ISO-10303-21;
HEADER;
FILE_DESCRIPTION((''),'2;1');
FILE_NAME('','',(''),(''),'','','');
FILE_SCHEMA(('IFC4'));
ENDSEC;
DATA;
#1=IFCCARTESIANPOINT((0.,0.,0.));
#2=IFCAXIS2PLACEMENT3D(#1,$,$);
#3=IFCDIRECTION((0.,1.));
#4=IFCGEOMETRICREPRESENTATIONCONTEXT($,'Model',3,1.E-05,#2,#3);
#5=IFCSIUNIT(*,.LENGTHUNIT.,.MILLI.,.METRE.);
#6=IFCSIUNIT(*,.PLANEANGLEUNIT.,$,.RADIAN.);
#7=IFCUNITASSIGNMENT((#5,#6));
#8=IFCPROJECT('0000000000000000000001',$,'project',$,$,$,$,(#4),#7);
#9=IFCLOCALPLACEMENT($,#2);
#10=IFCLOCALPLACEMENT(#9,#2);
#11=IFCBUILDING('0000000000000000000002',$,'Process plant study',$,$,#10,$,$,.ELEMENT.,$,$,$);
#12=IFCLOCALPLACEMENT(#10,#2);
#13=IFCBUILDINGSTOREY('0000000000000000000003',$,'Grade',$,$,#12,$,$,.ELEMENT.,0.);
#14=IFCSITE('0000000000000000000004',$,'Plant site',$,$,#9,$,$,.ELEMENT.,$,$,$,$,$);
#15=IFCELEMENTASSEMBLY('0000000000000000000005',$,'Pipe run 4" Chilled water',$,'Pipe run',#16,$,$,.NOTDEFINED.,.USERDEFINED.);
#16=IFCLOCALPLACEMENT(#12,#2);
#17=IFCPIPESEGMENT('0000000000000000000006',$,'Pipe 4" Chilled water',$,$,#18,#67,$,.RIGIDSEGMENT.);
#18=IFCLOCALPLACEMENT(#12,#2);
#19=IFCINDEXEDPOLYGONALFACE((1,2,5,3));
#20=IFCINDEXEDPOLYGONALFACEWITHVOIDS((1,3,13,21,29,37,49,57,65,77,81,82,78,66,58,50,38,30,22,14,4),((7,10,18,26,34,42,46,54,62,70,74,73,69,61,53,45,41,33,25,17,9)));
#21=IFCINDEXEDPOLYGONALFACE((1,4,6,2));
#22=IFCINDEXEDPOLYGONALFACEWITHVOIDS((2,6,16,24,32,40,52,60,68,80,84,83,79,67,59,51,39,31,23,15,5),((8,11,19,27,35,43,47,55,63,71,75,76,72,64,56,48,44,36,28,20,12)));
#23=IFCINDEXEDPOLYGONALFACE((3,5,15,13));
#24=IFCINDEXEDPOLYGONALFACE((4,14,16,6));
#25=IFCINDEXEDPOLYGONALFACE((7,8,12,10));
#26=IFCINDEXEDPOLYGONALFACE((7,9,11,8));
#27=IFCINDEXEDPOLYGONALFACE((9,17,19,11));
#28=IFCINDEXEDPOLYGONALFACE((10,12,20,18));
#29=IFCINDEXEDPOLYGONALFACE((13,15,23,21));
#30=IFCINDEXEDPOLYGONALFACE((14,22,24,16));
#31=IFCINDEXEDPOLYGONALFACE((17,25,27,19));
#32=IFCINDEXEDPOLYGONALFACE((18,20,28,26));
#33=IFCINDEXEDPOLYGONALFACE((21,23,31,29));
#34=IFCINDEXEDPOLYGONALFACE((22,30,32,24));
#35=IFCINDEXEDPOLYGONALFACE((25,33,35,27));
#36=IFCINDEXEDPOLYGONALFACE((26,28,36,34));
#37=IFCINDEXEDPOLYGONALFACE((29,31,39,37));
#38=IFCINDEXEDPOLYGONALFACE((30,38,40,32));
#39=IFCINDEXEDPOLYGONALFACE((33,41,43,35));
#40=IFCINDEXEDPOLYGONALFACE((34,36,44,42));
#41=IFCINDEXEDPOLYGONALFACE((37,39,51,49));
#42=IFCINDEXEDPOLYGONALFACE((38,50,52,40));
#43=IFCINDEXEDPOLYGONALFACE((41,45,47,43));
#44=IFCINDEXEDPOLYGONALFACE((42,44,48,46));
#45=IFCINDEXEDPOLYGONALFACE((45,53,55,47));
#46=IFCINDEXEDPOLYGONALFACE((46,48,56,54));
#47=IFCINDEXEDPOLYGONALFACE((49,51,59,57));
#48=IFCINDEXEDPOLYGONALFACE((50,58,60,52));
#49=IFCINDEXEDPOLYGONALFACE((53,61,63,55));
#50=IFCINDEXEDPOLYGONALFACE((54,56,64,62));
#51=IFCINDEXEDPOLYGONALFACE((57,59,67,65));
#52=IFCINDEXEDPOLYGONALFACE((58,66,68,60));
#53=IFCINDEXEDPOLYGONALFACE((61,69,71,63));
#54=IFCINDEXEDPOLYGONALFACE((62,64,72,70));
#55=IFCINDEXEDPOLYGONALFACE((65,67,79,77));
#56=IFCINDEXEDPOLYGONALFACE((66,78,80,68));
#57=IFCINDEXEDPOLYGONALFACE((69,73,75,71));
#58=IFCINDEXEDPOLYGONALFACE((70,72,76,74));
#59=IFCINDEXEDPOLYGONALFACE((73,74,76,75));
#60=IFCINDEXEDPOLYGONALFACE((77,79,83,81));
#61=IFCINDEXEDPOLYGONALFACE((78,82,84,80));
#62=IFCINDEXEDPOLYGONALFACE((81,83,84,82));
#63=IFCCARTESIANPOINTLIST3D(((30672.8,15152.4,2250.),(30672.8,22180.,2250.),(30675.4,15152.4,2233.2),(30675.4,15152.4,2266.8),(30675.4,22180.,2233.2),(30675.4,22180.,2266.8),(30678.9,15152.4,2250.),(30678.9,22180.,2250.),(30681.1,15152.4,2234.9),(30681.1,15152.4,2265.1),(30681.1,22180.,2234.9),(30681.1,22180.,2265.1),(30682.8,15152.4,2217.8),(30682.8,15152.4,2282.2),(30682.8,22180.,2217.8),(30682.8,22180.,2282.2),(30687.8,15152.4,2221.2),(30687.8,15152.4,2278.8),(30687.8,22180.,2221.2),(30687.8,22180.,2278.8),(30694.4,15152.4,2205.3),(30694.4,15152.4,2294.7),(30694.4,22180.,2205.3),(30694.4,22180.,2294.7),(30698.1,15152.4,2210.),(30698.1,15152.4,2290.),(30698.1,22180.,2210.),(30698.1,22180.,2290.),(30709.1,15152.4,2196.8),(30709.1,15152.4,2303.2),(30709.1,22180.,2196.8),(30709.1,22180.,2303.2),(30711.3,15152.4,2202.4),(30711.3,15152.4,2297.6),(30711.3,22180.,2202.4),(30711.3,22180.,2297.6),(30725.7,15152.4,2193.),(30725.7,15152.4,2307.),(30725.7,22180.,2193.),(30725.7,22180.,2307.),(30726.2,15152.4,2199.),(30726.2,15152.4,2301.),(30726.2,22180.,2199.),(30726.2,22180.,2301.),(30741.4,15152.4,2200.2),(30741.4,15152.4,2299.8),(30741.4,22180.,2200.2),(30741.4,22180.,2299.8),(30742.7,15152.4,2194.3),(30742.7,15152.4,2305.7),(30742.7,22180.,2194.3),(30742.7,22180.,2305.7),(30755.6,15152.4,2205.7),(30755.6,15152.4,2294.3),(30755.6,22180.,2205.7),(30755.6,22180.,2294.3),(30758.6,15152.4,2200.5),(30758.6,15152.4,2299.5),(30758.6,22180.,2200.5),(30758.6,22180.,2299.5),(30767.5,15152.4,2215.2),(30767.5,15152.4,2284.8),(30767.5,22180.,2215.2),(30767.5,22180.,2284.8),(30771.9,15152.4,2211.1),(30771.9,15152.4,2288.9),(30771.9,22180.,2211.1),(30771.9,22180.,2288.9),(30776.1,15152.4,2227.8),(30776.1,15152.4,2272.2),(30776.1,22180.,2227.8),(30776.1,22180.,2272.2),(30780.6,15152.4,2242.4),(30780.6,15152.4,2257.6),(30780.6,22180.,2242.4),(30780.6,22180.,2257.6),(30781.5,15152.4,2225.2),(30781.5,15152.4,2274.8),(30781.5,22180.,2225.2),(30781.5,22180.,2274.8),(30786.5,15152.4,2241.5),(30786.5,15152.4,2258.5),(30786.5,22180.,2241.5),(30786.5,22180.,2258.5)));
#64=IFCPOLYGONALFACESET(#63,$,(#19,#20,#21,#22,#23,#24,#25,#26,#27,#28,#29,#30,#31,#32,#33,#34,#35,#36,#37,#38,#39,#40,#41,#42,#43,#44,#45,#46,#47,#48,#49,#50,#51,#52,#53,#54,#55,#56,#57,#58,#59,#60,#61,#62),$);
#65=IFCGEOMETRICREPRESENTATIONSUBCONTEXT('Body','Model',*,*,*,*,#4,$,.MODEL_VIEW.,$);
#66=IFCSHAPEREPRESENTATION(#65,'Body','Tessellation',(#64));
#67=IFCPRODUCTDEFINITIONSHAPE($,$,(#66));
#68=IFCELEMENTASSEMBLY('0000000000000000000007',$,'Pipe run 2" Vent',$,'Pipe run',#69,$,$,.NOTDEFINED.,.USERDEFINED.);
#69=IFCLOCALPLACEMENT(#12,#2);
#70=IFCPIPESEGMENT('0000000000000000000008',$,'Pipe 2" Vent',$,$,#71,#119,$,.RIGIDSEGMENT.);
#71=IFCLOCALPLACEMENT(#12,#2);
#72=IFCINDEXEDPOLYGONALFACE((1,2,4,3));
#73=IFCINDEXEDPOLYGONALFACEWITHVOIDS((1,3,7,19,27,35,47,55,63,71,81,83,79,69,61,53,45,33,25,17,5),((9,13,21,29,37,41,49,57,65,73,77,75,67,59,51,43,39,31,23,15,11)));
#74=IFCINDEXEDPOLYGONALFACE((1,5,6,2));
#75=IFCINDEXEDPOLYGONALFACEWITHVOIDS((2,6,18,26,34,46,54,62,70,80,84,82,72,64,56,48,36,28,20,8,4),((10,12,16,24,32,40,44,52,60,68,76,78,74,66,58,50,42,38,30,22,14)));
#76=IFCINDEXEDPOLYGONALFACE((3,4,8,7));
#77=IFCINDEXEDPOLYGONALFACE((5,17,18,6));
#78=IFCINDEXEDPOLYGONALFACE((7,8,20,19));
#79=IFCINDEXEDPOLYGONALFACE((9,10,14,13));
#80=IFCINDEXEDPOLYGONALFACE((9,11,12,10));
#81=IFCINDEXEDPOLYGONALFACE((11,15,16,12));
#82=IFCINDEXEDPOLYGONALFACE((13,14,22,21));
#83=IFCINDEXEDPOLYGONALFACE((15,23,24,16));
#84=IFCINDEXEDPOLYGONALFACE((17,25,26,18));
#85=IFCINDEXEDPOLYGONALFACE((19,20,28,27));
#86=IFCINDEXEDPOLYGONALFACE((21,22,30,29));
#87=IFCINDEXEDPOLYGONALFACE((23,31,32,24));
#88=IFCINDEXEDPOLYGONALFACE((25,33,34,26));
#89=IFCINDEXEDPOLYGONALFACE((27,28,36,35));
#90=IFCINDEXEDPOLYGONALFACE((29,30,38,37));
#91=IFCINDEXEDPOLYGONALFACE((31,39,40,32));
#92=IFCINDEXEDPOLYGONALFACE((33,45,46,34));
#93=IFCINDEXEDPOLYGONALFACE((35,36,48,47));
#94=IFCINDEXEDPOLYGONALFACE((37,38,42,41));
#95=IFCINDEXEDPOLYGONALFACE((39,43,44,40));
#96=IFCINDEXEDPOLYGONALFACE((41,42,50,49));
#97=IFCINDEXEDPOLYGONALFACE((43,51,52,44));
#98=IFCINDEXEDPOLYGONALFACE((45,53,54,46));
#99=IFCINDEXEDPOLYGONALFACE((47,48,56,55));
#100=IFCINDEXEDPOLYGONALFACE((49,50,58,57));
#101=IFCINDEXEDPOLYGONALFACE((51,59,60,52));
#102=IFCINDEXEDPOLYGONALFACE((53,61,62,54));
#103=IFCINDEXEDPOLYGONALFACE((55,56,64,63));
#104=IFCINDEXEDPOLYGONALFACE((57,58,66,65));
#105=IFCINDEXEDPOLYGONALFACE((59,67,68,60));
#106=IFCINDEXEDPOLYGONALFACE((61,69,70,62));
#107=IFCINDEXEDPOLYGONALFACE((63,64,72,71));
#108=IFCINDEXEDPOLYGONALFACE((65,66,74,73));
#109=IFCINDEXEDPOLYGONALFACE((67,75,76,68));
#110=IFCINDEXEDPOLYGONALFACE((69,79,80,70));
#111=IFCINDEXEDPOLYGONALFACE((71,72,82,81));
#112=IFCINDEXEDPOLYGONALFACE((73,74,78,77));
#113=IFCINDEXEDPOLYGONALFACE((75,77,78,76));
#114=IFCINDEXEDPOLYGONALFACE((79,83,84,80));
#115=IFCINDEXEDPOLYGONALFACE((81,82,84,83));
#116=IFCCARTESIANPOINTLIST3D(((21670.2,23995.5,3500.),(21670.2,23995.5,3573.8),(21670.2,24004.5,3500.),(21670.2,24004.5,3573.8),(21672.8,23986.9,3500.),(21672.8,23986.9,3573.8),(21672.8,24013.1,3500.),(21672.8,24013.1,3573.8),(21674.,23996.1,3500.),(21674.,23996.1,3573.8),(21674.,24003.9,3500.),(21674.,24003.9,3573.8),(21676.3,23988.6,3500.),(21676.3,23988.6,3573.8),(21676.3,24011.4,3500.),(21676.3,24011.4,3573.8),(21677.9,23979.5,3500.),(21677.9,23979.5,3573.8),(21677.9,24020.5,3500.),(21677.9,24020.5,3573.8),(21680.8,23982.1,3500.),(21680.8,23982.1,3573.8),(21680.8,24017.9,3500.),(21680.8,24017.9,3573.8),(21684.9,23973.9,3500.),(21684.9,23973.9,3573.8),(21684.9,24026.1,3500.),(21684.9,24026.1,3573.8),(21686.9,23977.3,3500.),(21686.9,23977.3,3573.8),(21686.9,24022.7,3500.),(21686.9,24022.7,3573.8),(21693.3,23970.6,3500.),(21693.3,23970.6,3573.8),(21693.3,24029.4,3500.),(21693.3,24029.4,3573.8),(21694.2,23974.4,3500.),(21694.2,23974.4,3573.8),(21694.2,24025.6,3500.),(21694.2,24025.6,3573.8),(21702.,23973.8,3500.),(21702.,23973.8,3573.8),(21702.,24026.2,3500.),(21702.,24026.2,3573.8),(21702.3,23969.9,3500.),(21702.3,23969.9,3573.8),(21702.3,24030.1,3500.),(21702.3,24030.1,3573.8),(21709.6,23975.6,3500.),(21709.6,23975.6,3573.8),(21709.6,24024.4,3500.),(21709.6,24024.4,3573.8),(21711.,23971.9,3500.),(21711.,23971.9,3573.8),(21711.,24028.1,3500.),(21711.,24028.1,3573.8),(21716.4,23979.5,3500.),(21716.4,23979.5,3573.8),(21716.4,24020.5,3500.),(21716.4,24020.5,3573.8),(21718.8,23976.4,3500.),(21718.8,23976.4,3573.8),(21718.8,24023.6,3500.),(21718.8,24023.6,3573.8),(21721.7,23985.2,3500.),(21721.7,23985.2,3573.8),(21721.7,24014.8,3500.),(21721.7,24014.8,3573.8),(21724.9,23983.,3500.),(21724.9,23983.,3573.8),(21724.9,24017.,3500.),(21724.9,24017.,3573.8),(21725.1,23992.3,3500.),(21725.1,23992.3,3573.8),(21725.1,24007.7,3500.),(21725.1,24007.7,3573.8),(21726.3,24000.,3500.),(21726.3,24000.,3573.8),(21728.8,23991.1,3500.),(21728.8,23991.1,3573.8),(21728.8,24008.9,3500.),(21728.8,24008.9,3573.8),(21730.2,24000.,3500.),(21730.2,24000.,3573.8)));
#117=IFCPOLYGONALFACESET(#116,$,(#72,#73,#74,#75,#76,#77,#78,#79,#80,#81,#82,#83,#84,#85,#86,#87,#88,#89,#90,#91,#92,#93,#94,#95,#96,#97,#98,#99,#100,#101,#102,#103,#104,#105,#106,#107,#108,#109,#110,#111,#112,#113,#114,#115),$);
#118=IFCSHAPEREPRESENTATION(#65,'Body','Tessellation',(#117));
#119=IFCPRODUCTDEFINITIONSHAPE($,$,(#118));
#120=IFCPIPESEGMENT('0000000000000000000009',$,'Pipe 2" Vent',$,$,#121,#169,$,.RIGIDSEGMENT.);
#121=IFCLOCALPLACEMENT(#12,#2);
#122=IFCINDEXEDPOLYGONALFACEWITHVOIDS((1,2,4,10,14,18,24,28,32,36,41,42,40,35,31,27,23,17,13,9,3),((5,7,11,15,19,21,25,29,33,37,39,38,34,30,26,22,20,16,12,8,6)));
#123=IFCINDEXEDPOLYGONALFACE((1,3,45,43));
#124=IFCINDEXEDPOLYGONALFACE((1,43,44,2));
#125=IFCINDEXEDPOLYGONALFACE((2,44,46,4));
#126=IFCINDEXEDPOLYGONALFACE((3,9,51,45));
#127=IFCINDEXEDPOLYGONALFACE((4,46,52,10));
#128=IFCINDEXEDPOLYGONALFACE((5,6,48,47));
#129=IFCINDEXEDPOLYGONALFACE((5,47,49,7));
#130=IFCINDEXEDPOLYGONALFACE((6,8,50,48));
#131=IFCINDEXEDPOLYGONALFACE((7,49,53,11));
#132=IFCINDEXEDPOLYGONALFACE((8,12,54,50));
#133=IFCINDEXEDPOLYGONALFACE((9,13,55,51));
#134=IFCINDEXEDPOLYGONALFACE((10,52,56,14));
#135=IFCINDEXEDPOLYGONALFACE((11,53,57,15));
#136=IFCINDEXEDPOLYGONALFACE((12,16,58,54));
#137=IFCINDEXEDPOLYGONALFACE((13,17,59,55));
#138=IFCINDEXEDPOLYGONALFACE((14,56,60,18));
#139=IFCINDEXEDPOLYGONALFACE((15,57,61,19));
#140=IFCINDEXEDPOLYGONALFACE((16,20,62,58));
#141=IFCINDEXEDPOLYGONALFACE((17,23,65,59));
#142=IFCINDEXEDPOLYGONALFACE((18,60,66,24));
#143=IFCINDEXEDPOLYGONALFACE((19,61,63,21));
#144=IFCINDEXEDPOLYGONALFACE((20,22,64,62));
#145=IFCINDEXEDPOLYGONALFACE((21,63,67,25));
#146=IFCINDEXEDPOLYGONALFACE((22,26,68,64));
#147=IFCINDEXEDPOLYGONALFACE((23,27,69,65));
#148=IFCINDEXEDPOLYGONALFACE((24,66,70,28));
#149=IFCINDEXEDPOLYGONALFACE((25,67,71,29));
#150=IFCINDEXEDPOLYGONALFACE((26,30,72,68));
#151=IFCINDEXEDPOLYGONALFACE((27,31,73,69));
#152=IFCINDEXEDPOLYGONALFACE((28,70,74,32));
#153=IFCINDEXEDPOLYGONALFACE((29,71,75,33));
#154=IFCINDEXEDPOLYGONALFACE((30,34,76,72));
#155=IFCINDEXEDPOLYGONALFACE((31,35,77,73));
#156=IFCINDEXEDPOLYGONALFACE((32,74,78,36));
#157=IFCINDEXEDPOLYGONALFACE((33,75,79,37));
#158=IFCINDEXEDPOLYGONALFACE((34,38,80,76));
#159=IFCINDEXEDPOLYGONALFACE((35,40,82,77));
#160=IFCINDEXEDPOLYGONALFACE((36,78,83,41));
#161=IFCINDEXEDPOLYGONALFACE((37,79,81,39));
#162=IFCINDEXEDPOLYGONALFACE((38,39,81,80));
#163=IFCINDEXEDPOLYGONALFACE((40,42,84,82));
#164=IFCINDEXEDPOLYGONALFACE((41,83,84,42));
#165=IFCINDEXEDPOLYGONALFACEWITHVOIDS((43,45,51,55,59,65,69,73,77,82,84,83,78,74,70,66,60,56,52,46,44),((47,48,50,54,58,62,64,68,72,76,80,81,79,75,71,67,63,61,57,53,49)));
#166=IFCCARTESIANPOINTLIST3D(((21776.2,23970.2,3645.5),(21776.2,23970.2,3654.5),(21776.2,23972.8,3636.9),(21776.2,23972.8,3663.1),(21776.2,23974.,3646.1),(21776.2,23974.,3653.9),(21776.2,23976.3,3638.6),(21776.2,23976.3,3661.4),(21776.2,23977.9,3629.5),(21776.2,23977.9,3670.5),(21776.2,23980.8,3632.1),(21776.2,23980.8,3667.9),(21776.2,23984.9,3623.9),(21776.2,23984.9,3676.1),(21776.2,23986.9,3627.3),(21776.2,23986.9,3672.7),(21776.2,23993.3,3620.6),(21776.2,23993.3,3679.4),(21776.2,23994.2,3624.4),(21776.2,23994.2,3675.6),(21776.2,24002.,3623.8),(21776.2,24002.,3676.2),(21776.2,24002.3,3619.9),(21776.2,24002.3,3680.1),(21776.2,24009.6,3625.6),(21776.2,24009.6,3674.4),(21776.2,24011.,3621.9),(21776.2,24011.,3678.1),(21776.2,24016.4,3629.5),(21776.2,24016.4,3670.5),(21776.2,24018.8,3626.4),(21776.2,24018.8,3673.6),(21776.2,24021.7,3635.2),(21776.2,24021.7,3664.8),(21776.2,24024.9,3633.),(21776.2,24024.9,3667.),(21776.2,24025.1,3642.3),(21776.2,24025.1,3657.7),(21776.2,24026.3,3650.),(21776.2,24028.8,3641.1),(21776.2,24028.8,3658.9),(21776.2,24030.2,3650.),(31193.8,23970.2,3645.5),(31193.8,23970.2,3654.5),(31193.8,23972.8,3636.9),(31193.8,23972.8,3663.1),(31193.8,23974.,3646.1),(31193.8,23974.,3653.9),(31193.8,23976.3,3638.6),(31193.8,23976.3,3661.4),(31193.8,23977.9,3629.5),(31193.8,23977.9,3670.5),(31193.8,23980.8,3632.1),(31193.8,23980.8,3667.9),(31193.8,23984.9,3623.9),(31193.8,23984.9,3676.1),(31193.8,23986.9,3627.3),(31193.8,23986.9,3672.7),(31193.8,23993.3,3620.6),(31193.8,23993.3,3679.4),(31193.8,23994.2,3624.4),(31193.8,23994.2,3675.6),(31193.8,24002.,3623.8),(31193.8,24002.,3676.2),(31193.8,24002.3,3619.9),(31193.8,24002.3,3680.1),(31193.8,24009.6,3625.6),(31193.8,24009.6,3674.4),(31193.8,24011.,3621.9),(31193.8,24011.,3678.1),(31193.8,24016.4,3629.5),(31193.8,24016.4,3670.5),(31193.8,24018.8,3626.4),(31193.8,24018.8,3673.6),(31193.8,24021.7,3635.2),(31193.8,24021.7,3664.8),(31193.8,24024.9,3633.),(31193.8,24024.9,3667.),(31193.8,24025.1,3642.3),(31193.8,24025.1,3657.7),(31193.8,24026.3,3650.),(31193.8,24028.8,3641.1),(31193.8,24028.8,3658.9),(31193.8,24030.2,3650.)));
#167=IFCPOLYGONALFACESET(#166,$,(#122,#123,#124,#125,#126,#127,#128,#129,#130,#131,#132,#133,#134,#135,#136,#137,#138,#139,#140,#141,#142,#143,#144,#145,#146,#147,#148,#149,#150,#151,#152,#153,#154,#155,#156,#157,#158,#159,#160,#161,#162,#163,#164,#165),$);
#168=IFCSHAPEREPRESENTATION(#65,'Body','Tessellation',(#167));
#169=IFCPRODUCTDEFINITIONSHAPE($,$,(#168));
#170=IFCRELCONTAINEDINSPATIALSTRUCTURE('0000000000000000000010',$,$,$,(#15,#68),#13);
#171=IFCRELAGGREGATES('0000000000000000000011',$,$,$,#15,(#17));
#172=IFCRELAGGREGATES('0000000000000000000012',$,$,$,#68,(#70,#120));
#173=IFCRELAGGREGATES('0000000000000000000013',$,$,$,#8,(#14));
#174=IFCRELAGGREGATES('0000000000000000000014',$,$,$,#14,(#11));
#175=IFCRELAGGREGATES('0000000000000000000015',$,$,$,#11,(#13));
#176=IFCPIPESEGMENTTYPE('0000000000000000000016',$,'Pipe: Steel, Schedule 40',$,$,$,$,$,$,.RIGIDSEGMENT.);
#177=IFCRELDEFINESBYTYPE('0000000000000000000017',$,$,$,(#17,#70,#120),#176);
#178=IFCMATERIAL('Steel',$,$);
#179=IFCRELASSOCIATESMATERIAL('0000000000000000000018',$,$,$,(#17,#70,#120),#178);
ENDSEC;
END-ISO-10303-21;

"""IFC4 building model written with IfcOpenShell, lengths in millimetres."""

from ifc_helpers import new_model, si_unit, direction, frame, origin, origin_with_axes, origin_2d, place, context, subcontext, project, spatial, hollow_circle, extrude, material, type_object, element, aggregate, save


model = new_model("IFC4")

# Units and contexts
model_context = context("Model", 3, precision=1e-05, world=origin(), true_north=direction((0.0, 1.0)))
body_context = subcontext(model_context, "Body", "Model", "MODEL_VIEW")
ifc_project = project(units=[si_unit("LENGTHUNIT", "METRE", prefix="MILLI"), si_unit("PLANEANGLEUNIT", "RADIAN")], contexts=[model_context])

# Site, building, storey
site_placement = place(None, origin())
site = spatial("IfcSite", under=ifc_project, at=site_placement, Name="Plant site", CompositionType="ELEMENT")
building_placement = place(site_placement, origin())
building = spatial("IfcBuilding", under=site, at=building_placement, Name="Process plant study", CompositionType="ELEMENT")
storey_placement = place(building_placement, origin())
storey = spatial("IfcBuildingStorey", under=building, at=storey_placement, Name="Grade", CompositionType="ELEMENT", Elevation=0.0)

# Shared definitions
ifc_material = material(Name="Steel")
pipe_segment_type = type_object("IfcPipeSegmentType", Name="Pipe: Steel, Schedule 40", PredefinedType="RIGIDSEGMENT")

# Element assemblies, pipe segments
assembly_1_placement = place(storey_placement, origin_with_axes())
assembly_1 = element("IfcElementAssembly", 1, at=assembly_1_placement, inside=storey, Name="Pipe run 4\" Chilled water", ObjectType="Pipe run", AssemblyPlace="NOTDEFINED", PredefinedType="USERDEFINED")
pipe_segment_1_placement = place(storey_placement, origin_with_axes())
pipe_segment_1 = element("IfcPipeSegment", 2, at=pipe_segment_1_placement, type_object=pipe_segment_type, material=ifc_material, Name="Pipe 4\" Chilled water", PredefinedType="RIGIDSEGMENT", context=body_context, shape_type="SweptSolid", body=[
    extrude(hollow_circle(Radius=57.1, WallThickness=6.0, at=origin_2d()), frame((30730.0, 15152.4, 2250.0), z_axis=(0.0, 1.0, 0.0), x_axis=(-1.0, 0.0, 0.0)), (0.0, 0.0, 1.0), 7027.6),
])
assembly_2_placement = place(storey_placement, origin_with_axes())
assembly_2 = element("IfcElementAssembly", 3, at=assembly_2_placement, inside=storey, Name="Pipe run 2\" Vent", ObjectType="Pipe run", AssemblyPlace="NOTDEFINED", PredefinedType="USERDEFINED")
pipe_segment_2_placement = place(storey_placement, origin_with_axes())
pipe_segment_2 = element("IfcPipeSegment", 4, at=pipe_segment_2_placement, type_object=pipe_segment_type, material=ifc_material, Name="Pipe 2\" Vent", PredefinedType="RIGIDSEGMENT", context=body_context, shape_type="SweptSolid", body=[
    extrude(hollow_circle(Radius=30.2, WallThickness=3.9, at=origin_2d()), frame((21700.0, 24000.0, 3500.0), z_axis=(0.0, 0.0, 1.0), x_axis=(1.0, 0.0, 0.0)), (0.0, 0.0, 1.0), 73.8),
])
pipe_segment_3_placement = place(storey_placement, origin_with_axes())
pipe_segment_3 = element("IfcPipeSegment", 5, at=pipe_segment_3_placement, type_object=pipe_segment_type, material=ifc_material, Name="Pipe 2\" Vent", PredefinedType="RIGIDSEGMENT", context=body_context, shape_type="SweptSolid", body=[
    extrude(hollow_circle(Radius=30.2, WallThickness=3.9, at=origin_2d()), frame((21776.2, 24000.0, 3650.0), z_axis=(1.0, 0.0, 0.0), x_axis=(0.0, 1.0, 0.0)), (0.0, 0.0, 1.0), 9417.6),
])

aggregate(assembly_1, [pipe_segment_1])
aggregate(assembly_2, [pipe_segment_2, pipe_segment_3])

save(model, "model.ifc")
